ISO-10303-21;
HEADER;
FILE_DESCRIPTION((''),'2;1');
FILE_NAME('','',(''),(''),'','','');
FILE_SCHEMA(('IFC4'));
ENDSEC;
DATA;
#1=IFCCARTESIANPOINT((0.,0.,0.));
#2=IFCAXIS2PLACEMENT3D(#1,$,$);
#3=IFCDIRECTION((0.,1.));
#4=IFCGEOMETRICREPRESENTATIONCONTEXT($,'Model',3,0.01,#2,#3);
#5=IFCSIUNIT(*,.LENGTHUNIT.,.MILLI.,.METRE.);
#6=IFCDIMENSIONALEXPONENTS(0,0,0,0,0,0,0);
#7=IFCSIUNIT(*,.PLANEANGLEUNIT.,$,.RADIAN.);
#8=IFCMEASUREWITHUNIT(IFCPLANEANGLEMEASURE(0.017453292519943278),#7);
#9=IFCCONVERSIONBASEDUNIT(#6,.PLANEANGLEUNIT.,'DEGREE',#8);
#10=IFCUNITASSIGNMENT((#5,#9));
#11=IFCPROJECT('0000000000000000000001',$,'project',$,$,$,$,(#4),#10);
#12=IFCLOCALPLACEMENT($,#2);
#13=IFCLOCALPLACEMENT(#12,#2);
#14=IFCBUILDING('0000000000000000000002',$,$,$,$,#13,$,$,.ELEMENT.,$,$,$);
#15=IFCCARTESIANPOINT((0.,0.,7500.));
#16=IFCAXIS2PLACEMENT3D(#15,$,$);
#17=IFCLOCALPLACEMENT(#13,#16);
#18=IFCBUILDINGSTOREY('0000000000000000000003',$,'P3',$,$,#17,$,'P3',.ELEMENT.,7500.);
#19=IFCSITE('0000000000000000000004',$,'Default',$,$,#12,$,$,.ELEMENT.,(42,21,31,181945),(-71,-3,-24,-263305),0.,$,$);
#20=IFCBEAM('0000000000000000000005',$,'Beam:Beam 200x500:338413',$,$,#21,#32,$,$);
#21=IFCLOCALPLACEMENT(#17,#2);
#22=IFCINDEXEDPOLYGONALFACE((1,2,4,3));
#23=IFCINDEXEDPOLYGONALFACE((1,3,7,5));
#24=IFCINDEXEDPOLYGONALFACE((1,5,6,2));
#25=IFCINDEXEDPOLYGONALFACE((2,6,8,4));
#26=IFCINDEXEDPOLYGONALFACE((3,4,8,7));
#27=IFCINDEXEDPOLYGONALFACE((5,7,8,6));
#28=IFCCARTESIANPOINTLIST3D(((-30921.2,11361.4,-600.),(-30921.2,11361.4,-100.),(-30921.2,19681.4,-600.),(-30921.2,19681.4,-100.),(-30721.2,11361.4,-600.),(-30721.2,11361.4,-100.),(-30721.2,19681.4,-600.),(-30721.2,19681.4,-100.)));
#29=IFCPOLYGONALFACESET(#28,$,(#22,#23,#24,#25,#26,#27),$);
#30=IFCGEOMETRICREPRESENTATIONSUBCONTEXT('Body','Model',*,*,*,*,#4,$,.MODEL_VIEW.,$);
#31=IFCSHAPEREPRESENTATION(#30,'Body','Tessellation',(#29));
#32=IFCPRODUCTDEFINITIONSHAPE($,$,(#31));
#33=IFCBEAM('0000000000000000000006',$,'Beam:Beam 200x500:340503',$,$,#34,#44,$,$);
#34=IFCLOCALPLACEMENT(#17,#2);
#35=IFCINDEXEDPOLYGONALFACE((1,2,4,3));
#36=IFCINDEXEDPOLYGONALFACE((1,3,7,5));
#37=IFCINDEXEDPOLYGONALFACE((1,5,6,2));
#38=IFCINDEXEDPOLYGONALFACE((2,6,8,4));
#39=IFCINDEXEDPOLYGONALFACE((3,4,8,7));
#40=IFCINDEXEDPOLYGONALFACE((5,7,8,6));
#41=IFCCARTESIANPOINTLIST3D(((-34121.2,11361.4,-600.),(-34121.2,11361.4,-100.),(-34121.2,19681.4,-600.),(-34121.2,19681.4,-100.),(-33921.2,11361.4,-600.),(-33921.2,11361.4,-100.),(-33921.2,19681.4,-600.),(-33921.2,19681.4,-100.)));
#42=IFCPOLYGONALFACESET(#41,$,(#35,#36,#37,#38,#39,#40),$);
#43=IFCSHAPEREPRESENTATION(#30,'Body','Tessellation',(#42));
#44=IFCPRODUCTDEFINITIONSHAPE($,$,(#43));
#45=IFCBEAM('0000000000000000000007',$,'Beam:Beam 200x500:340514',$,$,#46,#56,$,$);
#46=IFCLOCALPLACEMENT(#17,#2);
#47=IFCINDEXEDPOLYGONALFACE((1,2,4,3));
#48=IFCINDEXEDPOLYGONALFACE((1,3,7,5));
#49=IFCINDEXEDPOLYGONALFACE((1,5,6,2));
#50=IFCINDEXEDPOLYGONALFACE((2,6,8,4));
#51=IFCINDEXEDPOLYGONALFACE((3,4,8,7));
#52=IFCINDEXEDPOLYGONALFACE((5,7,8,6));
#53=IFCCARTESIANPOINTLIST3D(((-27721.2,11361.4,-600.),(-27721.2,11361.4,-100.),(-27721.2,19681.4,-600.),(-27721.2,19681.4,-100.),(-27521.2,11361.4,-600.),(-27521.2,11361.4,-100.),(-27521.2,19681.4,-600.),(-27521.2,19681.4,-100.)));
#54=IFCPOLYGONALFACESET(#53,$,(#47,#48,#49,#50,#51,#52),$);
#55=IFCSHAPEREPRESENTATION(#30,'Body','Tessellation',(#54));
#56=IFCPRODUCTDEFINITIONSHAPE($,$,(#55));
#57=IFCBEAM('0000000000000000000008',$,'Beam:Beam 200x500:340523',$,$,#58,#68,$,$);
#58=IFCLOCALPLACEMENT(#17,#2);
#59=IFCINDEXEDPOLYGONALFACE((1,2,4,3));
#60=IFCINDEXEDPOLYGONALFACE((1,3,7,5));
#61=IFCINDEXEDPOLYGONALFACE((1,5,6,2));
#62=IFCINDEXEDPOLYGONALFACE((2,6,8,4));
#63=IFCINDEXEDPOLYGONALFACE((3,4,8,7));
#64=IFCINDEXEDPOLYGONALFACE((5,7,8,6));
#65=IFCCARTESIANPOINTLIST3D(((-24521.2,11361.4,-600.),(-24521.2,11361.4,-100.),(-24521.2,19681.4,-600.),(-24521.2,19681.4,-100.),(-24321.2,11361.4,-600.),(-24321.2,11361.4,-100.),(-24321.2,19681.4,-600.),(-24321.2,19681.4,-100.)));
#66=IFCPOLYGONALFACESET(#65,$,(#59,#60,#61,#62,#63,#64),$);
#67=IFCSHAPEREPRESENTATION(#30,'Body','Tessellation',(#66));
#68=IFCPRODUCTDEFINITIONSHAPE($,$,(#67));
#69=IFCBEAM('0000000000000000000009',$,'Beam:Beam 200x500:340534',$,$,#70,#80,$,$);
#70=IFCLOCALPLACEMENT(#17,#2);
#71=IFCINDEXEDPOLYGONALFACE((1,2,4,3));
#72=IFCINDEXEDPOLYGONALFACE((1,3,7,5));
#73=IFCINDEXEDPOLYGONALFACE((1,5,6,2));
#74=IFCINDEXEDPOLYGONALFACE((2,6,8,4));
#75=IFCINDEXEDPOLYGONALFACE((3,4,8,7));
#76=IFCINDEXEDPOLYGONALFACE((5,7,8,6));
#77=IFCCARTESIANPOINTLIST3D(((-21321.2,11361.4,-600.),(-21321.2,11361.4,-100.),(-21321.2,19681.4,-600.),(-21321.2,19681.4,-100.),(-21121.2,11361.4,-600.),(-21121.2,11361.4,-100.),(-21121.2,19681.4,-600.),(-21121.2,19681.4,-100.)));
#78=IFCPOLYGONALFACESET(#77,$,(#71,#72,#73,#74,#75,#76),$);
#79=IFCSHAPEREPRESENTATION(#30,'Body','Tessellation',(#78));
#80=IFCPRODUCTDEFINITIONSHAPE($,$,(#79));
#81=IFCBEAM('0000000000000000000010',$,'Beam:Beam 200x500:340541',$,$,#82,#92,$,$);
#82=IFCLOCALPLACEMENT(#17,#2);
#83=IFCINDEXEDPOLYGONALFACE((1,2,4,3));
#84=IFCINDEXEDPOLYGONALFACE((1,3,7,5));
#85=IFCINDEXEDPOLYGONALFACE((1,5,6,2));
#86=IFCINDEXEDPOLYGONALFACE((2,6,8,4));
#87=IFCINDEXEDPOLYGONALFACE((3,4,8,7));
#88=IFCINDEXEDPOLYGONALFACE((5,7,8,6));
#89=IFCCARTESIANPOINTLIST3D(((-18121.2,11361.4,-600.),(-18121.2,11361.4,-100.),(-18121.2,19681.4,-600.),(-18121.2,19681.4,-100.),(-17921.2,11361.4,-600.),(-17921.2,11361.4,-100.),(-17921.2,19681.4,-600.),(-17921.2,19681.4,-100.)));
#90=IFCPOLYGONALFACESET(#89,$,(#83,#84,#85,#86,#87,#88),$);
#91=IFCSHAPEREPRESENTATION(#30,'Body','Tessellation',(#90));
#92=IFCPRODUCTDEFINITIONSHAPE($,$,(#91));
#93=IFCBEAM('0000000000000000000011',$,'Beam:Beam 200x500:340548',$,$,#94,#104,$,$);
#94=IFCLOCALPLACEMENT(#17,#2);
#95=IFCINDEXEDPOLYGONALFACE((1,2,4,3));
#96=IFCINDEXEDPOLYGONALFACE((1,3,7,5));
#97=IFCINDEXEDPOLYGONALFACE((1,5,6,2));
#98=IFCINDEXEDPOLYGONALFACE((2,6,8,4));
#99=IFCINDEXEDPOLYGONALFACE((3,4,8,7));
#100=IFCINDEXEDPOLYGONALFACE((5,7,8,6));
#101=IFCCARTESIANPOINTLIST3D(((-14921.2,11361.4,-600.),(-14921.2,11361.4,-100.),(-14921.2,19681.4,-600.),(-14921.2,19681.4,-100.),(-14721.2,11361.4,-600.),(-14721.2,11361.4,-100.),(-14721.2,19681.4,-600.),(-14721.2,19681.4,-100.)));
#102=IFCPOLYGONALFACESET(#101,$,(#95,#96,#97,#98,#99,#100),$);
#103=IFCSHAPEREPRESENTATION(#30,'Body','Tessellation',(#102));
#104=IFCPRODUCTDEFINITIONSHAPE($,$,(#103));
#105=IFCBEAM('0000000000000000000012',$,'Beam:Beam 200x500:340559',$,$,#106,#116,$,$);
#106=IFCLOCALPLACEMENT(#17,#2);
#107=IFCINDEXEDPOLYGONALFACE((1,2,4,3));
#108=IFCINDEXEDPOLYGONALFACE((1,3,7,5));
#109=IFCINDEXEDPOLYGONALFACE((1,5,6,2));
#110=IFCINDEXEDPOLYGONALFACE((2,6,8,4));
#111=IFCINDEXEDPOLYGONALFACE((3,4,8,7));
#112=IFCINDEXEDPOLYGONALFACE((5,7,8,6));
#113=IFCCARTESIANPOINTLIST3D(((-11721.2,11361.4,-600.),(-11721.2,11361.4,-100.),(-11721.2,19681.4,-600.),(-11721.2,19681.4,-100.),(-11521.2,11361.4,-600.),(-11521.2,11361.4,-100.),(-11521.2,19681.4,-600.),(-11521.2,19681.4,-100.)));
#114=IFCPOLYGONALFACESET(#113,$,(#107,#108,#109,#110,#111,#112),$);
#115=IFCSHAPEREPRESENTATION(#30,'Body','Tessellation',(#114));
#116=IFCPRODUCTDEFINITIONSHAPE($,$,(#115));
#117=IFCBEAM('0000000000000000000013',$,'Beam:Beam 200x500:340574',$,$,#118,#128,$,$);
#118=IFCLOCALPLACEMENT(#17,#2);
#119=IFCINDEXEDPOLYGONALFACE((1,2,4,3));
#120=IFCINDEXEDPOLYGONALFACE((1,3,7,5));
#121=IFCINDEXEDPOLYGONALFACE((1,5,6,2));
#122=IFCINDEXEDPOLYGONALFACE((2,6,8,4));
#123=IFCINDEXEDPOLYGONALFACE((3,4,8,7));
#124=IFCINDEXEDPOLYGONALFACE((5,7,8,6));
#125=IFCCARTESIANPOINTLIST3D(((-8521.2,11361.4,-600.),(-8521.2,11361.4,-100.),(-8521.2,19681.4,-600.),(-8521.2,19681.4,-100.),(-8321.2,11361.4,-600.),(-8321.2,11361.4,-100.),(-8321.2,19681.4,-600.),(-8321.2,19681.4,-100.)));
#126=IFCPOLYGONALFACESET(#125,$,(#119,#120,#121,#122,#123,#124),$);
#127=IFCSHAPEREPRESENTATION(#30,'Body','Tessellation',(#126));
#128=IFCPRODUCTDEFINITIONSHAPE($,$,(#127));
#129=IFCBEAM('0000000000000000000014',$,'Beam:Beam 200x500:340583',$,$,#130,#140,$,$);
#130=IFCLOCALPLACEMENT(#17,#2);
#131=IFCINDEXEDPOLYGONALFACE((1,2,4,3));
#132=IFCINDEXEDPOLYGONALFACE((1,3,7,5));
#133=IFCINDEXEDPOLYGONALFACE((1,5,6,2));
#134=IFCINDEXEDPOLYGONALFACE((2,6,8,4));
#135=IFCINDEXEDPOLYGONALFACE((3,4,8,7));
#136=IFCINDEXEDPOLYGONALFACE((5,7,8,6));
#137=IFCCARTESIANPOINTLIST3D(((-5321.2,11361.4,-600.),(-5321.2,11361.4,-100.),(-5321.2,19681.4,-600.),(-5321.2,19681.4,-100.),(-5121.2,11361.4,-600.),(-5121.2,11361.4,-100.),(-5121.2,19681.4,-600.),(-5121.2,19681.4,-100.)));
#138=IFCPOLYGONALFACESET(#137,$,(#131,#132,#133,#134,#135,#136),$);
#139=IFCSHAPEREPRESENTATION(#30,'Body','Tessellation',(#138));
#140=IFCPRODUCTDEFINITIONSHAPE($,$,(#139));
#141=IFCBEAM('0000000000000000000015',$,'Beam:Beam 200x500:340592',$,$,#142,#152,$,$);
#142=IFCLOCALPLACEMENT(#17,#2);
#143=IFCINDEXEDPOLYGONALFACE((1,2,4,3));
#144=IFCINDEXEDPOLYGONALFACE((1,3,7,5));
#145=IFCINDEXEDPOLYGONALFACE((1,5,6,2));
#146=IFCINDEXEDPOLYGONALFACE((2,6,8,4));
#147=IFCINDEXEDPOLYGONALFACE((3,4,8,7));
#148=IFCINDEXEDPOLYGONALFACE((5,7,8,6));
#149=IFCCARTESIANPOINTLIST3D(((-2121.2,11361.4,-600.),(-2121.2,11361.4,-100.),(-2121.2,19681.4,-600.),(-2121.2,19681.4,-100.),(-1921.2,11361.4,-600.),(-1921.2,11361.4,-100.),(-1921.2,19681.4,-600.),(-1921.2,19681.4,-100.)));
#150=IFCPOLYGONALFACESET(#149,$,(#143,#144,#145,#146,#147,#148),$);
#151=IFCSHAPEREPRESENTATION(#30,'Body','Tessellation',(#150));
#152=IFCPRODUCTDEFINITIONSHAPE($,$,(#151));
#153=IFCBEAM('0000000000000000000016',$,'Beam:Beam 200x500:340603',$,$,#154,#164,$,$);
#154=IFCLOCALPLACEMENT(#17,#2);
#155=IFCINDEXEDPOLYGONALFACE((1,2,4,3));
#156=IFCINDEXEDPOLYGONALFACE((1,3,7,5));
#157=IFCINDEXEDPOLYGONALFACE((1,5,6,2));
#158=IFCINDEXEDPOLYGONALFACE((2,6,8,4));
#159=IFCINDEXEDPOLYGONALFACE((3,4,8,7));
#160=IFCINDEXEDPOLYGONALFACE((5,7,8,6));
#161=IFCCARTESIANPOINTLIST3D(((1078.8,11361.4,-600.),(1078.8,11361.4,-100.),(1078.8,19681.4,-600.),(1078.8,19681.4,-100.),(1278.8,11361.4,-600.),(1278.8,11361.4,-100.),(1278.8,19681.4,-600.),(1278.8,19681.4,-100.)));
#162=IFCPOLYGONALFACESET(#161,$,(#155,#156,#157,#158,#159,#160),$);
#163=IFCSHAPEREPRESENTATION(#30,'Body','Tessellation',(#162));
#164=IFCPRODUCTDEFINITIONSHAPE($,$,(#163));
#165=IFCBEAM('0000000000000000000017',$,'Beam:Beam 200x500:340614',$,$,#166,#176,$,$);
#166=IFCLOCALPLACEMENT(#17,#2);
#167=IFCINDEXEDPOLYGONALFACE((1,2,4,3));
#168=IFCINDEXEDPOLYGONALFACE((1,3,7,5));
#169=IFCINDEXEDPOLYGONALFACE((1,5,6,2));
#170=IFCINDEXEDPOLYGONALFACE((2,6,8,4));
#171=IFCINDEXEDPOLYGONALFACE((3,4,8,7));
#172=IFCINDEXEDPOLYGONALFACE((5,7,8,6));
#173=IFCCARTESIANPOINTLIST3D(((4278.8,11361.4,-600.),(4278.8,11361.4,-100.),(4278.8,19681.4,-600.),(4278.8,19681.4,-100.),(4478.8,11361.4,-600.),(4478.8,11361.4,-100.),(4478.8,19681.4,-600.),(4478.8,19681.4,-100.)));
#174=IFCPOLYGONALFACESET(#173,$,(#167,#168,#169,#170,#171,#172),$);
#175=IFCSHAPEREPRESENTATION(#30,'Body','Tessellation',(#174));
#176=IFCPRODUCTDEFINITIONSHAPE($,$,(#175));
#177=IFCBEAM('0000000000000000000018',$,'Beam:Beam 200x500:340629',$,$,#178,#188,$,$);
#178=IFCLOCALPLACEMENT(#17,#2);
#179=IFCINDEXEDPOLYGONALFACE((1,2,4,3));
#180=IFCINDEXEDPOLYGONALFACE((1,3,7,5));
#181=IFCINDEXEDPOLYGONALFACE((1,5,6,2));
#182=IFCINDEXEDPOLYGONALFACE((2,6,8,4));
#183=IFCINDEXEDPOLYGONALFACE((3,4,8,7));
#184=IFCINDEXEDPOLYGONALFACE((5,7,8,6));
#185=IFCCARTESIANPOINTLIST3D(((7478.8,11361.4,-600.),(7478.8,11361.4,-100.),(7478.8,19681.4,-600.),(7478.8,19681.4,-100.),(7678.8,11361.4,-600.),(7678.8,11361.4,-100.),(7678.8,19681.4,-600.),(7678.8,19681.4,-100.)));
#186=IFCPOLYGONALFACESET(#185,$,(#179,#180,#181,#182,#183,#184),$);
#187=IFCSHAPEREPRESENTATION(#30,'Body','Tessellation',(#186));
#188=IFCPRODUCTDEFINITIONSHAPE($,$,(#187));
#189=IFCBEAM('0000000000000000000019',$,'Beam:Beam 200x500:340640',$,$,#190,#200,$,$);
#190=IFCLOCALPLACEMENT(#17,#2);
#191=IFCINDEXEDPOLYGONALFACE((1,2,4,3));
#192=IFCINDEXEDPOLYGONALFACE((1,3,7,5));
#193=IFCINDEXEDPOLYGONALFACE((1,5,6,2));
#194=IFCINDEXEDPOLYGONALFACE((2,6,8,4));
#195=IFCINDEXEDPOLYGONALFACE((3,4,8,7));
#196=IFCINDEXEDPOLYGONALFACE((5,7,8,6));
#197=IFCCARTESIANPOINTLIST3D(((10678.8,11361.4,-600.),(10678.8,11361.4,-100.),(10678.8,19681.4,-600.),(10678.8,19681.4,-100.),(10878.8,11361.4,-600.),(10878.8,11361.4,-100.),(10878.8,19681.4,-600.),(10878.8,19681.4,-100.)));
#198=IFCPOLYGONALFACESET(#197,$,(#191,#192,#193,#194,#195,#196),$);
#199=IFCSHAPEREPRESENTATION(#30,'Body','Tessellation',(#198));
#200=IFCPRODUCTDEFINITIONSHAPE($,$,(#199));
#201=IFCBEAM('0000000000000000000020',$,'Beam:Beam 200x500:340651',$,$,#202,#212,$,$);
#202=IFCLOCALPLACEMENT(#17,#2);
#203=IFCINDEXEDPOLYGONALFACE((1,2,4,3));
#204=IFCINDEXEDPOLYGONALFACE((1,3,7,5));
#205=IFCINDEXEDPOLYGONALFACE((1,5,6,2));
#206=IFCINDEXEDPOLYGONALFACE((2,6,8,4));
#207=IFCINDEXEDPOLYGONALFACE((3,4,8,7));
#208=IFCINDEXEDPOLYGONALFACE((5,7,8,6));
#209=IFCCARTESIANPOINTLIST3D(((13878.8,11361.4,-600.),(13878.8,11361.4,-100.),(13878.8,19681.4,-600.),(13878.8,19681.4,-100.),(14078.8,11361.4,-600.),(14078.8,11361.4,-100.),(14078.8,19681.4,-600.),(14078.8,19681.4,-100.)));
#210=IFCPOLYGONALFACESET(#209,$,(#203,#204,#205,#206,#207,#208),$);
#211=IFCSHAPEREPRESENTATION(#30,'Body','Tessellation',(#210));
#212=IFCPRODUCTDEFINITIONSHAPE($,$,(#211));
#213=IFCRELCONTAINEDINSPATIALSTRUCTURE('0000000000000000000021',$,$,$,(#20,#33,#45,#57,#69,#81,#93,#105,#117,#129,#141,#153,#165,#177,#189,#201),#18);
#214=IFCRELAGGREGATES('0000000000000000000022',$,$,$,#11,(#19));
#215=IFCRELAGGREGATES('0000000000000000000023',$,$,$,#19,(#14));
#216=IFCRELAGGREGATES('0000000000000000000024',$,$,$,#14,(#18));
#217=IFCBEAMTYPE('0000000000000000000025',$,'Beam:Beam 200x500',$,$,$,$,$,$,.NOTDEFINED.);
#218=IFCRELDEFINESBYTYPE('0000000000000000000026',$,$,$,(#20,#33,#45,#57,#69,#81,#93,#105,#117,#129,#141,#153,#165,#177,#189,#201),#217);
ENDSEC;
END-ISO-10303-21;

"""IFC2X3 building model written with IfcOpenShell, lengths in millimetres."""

from ifc_helpers import new_model, entity, si_unit, converted_unit, direction, frame, frame_2d, origin, place, context, subcontext, project, spatial, rectangle, extrude, type_object, element, save


model = new_model("IFC2X3")

# Units and contexts
model_context = context("Model", 3, precision=0.01, world=origin(), true_north=direction((0.0, 1.0)))
body_context = subcontext(model_context, "Body", "Model", "MODEL_VIEW")
ifc_project = project(units=[si_unit("LENGTHUNIT", "METRE", prefix="MILLI"), converted_unit("PLANEANGLEUNIT", "DEGREE", entity("IfcPlaneAngleMeasure", 0.017453292519943278), si_unit("PLANEANGLEUNIT", "RADIAN"), dimensions=[0, 0, 0, 0, 0, 0, 0])], contexts=[model_context])

# Site, building, storey
site_placement = place(None, origin())
site = spatial("IfcSite", under=ifc_project, at=site_placement, Name="Default", CompositionType="ELEMENT", RefLatitude=(42, 21, 31, 181945), RefLongitude=(-71, -3, -24, -263305), RefElevation=0.0)
building_placement = place(site_placement, origin())
building = spatial("IfcBuilding", under=site, at=building_placement, CompositionType="ELEMENT")
storey_placement = place(building_placement, frame((0.0, 0.0, 7500.0)))
storey = spatial("IfcBuildingStorey", under=building, at=storey_placement, Name="P3", LongName="P3", CompositionType="ELEMENT", Elevation=7500.0)

# Beams
beam_type_1 = type_object("IfcBeamType", Name="Beam:Beam 200x500", PredefinedType="NOTDEFINED")
beam_1_placement = place(storey_placement, frame((-30846.2, 19681.4, -100.0), z_axis=(0.0, 0.0, 1.0), x_axis=(0.0, -1.0, 0.0)))
element("IfcBeam", 1, at=beam_1_placement, inside=storey, type_object=beam_type_1, Name="Beam:Beam 200x500:338413", context=body_context, shape_type="SweptSolid", body=[
    extrude(rectangle(XDim=500.0, YDim=200.0, at=frame_2d((0.0, 0.0), x_axis=(1.0, 0.0))), frame((0.0, 25.0, -250.0), z_axis=(1.0, 0.0, 0.0), x_axis=(0.0, 0.0, -1.0)), (0.0, 0.0, 1.0), 8320.0),
])
beam_2_placement = place(storey_placement, frame((-34046.2, 19681.4, -100.0), z_axis=(0.0, 0.0, 1.0), x_axis=(0.0, -1.0, 0.0)))
element("IfcBeam", 2, at=beam_2_placement, inside=storey, type_object=beam_type_1, Name="Beam:Beam 200x500:340503", context=body_context, shape_type="SweptSolid", body=[
    extrude(rectangle(XDim=500.0, YDim=200.0, at=frame_2d((0.0, 0.0), x_axis=(1.0, 0.0))), frame((0.0, 25.0, -250.0), z_axis=(1.0, 0.0, 0.0), x_axis=(0.0, 0.0, -1.0)), (0.0, 0.0, 1.0), 8320.0),
])
beam_3_placement = place(storey_placement, frame((-27646.2, 19681.4, -100.0), z_axis=(0.0, 0.0, 1.0), x_axis=(0.0, -1.0, 0.0)))
element("IfcBeam", 3, at=beam_3_placement, inside=storey, type_object=beam_type_1, Name="Beam:Beam 200x500:340514", context=body_context, shape_type="SweptSolid", body=[
    extrude(rectangle(XDim=500.0, YDim=200.0, at=frame_2d((0.0, 0.0), x_axis=(1.0, 0.0))), frame((0.0, 25.0, -250.0), z_axis=(1.0, 0.0, 0.0), x_axis=(0.0, 0.0, -1.0)), (0.0, 0.0, 1.0), 8320.0),
])
for number, where, z_axis, x_axis, name in (
    (4, (-24446.2, 19681.4, -100.0), (0.0, 0.0, 1.0), (0.0, -1.0, 0.0), "Beam:Beam 200x500:340523"),
    (5, (-21246.2, 19681.4, -100.0), (0.0, 0.0, 1.0), (0.0, -1.0, 0.0), "Beam:Beam 200x500:340534"),
):
    element("IfcBeam", number, at=place(storey_placement, frame(where, z_axis=z_axis, x_axis=x_axis)), inside=storey, type_object=beam_type_1, Name=name, context=body_context, shape_type="SweptSolid", body=[
        extrude(rectangle(XDim=500.0, YDim=200.0, at=frame_2d((0.0, 0.0), x_axis=(1.0, 0.0))), frame((0.0, 25.0, -250.0), z_axis=(1.0, 0.0, 0.0), x_axis=(0.0, 0.0, -1.0)), (0.0, 0.0, 1.0), 8320.0),
    ])
for number, where, z_axis, x_axis, name in (
    (6, (-18046.2, 19681.4, -100.0), (0.0, 0.0, 1.0), (0.0, -1.0, 0.0), "Beam:Beam 200x500:340541"),
    (7, (-14846.2, 19681.4, -100.0), (0.0, 0.0, 1.0), (0.0, -1.0, 0.0), "Beam:Beam 200x500:340548"),
    (8, (-11646.2, 19681.4, -100.0), (0.0, 0.0, 1.0), (0.0, -1.0, 0.0), "Beam:Beam 200x500:340559"),
):
    element("IfcBeam", number, at=place(storey_placement, frame(where, z_axis=z_axis, x_axis=x_axis)), inside=storey, type_object=beam_type_1, Name=name, context=body_context, shape_type="SweptSolid", body=[
        extrude(rectangle(XDim=500.0, YDim=200.0, at=frame_2d((0.0, 0.0), x_axis=(1.0, 0.0))), frame((0.0, 25.0, -250.0), z_axis=(1.0, 0.0, 0.0), x_axis=(0.0, 0.0, -1.0)), (0.0, 0.0, 1.0), 8320.0),
    ])
for number, where, z_axis, x_axis, name in (
    (9, (-8446.2, 19681.4, -100.0), (0.0, 0.0, 1.0), (0.0, -1.0, 0.0), "Beam:Beam 200x500:340574"),
    (10, (-5246.2, 19681.4, -100.0), (0.0, 0.0, 1.0), (0.0, -1.0, 0.0), "Beam:Beam 200x500:340583"),
):
    element("IfcBeam", number, at=place(storey_placement, frame(where, z_axis=z_axis, x_axis=x_axis)), inside=storey, type_object=beam_type_1, Name=name, context=body_context, shape_type="SweptSolid", body=[
        extrude(rectangle(XDim=500.0, YDim=200.0, at=frame_2d((0.0, 0.0), x_axis=(1.0, 0.0))), frame((0.0, 25.0, -250.0), z_axis=(1.0, 0.0, 0.0), x_axis=(0.0, 0.0, -1.0)), (0.0, 0.0, 1.0), 8320.0),
    ])
for number, where, z_axis, x_axis, name in (
    (11, (-2046.2, 19681.4, -100.0), (0.0, 0.0, 1.0), (0.0, -1.0, 0.0), "Beam:Beam 200x500:340592"),
    (12, (1153.8, 19681.4, -100.0), (0.0, 0.0, 1.0), (0.0, -1.0, 0.0), "Beam:Beam 200x500:340603"),
):
    element("IfcBeam", number, at=place(storey_placement, frame(where, z_axis=z_axis, x_axis=x_axis)), inside=storey, type_object=beam_type_1, Name=name, context=body_context, shape_type="SweptSolid", body=[
        extrude(rectangle(XDim=500.0, YDim=200.0, at=frame_2d((0.0, 0.0), x_axis=(1.0, 0.0))), frame((0.0, 25.0, -250.0), z_axis=(1.0, 0.0, 0.0), x_axis=(0.0, 0.0, -1.0)), (0.0, 0.0, 1.0), 8320.0),
    ])
beam_4_placement = place(storey_placement, frame((4353.8, 19681.4, -100.0), z_axis=(0.0, 0.0, 1.0), x_axis=(0.0, -1.0, 0.0)))
element("IfcBeam", 13, at=beam_4_placement, inside=storey, type_object=beam_type_1, Name="Beam:Beam 200x500:340614", context=body_context, shape_type="SweptSolid", body=[
    extrude(rectangle(XDim=500.0, YDim=200.0, at=frame_2d((0.0, 0.0), x_axis=(1.0, 0.0))), frame((0.0, 25.0, -250.0), z_axis=(1.0, 0.0, 0.0), x_axis=(0.0, 0.0, -1.0)), (0.0, 0.0, 1.0), 8320.0),
])
beam_5_placement = place(storey_placement, frame((7553.8, 19681.4, -100.0), z_axis=(0.0, 0.0, 1.0), x_axis=(0.0, -1.0, 0.0)))
element("IfcBeam", 14, at=beam_5_placement, inside=storey, type_object=beam_type_1, Name="Beam:Beam 200x500:340629", context=body_context, shape_type="SweptSolid", body=[
    extrude(rectangle(XDim=500.0, YDim=200.0, at=frame_2d((0.0, 0.0), x_axis=(1.0, 0.0))), frame((0.0, 25.0, -250.0), z_axis=(1.0, 0.0, 0.0), x_axis=(0.0, 0.0, -1.0)), (0.0, 0.0, 1.0), 8320.0),
])
for number, where, z_axis, x_axis, name in (
    (15, (10753.8, 19681.4, -100.0), (0.0, 0.0, 1.0), (0.0, -1.0, 0.0), "Beam:Beam 200x500:340640"),
    (16, (13953.8, 19681.4, -100.0), (0.0, 0.0, 1.0), (0.0, -1.0, 0.0), "Beam:Beam 200x500:340651"),
):
    element("IfcBeam", number, at=place(storey_placement, frame(where, z_axis=z_axis, x_axis=x_axis)), inside=storey, type_object=beam_type_1, Name=name, context=body_context, shape_type="SweptSolid", body=[
        extrude(rectangle(XDim=500.0, YDim=200.0, at=frame_2d((0.0, 0.0), x_axis=(1.0, 0.0))), frame((0.0, 25.0, -250.0), z_axis=(1.0, 0.0, 0.0), x_axis=(0.0, 0.0, -1.0)), (0.0, 0.0, 1.0), 8320.0),
    ])

save(model, "model.ifc")
